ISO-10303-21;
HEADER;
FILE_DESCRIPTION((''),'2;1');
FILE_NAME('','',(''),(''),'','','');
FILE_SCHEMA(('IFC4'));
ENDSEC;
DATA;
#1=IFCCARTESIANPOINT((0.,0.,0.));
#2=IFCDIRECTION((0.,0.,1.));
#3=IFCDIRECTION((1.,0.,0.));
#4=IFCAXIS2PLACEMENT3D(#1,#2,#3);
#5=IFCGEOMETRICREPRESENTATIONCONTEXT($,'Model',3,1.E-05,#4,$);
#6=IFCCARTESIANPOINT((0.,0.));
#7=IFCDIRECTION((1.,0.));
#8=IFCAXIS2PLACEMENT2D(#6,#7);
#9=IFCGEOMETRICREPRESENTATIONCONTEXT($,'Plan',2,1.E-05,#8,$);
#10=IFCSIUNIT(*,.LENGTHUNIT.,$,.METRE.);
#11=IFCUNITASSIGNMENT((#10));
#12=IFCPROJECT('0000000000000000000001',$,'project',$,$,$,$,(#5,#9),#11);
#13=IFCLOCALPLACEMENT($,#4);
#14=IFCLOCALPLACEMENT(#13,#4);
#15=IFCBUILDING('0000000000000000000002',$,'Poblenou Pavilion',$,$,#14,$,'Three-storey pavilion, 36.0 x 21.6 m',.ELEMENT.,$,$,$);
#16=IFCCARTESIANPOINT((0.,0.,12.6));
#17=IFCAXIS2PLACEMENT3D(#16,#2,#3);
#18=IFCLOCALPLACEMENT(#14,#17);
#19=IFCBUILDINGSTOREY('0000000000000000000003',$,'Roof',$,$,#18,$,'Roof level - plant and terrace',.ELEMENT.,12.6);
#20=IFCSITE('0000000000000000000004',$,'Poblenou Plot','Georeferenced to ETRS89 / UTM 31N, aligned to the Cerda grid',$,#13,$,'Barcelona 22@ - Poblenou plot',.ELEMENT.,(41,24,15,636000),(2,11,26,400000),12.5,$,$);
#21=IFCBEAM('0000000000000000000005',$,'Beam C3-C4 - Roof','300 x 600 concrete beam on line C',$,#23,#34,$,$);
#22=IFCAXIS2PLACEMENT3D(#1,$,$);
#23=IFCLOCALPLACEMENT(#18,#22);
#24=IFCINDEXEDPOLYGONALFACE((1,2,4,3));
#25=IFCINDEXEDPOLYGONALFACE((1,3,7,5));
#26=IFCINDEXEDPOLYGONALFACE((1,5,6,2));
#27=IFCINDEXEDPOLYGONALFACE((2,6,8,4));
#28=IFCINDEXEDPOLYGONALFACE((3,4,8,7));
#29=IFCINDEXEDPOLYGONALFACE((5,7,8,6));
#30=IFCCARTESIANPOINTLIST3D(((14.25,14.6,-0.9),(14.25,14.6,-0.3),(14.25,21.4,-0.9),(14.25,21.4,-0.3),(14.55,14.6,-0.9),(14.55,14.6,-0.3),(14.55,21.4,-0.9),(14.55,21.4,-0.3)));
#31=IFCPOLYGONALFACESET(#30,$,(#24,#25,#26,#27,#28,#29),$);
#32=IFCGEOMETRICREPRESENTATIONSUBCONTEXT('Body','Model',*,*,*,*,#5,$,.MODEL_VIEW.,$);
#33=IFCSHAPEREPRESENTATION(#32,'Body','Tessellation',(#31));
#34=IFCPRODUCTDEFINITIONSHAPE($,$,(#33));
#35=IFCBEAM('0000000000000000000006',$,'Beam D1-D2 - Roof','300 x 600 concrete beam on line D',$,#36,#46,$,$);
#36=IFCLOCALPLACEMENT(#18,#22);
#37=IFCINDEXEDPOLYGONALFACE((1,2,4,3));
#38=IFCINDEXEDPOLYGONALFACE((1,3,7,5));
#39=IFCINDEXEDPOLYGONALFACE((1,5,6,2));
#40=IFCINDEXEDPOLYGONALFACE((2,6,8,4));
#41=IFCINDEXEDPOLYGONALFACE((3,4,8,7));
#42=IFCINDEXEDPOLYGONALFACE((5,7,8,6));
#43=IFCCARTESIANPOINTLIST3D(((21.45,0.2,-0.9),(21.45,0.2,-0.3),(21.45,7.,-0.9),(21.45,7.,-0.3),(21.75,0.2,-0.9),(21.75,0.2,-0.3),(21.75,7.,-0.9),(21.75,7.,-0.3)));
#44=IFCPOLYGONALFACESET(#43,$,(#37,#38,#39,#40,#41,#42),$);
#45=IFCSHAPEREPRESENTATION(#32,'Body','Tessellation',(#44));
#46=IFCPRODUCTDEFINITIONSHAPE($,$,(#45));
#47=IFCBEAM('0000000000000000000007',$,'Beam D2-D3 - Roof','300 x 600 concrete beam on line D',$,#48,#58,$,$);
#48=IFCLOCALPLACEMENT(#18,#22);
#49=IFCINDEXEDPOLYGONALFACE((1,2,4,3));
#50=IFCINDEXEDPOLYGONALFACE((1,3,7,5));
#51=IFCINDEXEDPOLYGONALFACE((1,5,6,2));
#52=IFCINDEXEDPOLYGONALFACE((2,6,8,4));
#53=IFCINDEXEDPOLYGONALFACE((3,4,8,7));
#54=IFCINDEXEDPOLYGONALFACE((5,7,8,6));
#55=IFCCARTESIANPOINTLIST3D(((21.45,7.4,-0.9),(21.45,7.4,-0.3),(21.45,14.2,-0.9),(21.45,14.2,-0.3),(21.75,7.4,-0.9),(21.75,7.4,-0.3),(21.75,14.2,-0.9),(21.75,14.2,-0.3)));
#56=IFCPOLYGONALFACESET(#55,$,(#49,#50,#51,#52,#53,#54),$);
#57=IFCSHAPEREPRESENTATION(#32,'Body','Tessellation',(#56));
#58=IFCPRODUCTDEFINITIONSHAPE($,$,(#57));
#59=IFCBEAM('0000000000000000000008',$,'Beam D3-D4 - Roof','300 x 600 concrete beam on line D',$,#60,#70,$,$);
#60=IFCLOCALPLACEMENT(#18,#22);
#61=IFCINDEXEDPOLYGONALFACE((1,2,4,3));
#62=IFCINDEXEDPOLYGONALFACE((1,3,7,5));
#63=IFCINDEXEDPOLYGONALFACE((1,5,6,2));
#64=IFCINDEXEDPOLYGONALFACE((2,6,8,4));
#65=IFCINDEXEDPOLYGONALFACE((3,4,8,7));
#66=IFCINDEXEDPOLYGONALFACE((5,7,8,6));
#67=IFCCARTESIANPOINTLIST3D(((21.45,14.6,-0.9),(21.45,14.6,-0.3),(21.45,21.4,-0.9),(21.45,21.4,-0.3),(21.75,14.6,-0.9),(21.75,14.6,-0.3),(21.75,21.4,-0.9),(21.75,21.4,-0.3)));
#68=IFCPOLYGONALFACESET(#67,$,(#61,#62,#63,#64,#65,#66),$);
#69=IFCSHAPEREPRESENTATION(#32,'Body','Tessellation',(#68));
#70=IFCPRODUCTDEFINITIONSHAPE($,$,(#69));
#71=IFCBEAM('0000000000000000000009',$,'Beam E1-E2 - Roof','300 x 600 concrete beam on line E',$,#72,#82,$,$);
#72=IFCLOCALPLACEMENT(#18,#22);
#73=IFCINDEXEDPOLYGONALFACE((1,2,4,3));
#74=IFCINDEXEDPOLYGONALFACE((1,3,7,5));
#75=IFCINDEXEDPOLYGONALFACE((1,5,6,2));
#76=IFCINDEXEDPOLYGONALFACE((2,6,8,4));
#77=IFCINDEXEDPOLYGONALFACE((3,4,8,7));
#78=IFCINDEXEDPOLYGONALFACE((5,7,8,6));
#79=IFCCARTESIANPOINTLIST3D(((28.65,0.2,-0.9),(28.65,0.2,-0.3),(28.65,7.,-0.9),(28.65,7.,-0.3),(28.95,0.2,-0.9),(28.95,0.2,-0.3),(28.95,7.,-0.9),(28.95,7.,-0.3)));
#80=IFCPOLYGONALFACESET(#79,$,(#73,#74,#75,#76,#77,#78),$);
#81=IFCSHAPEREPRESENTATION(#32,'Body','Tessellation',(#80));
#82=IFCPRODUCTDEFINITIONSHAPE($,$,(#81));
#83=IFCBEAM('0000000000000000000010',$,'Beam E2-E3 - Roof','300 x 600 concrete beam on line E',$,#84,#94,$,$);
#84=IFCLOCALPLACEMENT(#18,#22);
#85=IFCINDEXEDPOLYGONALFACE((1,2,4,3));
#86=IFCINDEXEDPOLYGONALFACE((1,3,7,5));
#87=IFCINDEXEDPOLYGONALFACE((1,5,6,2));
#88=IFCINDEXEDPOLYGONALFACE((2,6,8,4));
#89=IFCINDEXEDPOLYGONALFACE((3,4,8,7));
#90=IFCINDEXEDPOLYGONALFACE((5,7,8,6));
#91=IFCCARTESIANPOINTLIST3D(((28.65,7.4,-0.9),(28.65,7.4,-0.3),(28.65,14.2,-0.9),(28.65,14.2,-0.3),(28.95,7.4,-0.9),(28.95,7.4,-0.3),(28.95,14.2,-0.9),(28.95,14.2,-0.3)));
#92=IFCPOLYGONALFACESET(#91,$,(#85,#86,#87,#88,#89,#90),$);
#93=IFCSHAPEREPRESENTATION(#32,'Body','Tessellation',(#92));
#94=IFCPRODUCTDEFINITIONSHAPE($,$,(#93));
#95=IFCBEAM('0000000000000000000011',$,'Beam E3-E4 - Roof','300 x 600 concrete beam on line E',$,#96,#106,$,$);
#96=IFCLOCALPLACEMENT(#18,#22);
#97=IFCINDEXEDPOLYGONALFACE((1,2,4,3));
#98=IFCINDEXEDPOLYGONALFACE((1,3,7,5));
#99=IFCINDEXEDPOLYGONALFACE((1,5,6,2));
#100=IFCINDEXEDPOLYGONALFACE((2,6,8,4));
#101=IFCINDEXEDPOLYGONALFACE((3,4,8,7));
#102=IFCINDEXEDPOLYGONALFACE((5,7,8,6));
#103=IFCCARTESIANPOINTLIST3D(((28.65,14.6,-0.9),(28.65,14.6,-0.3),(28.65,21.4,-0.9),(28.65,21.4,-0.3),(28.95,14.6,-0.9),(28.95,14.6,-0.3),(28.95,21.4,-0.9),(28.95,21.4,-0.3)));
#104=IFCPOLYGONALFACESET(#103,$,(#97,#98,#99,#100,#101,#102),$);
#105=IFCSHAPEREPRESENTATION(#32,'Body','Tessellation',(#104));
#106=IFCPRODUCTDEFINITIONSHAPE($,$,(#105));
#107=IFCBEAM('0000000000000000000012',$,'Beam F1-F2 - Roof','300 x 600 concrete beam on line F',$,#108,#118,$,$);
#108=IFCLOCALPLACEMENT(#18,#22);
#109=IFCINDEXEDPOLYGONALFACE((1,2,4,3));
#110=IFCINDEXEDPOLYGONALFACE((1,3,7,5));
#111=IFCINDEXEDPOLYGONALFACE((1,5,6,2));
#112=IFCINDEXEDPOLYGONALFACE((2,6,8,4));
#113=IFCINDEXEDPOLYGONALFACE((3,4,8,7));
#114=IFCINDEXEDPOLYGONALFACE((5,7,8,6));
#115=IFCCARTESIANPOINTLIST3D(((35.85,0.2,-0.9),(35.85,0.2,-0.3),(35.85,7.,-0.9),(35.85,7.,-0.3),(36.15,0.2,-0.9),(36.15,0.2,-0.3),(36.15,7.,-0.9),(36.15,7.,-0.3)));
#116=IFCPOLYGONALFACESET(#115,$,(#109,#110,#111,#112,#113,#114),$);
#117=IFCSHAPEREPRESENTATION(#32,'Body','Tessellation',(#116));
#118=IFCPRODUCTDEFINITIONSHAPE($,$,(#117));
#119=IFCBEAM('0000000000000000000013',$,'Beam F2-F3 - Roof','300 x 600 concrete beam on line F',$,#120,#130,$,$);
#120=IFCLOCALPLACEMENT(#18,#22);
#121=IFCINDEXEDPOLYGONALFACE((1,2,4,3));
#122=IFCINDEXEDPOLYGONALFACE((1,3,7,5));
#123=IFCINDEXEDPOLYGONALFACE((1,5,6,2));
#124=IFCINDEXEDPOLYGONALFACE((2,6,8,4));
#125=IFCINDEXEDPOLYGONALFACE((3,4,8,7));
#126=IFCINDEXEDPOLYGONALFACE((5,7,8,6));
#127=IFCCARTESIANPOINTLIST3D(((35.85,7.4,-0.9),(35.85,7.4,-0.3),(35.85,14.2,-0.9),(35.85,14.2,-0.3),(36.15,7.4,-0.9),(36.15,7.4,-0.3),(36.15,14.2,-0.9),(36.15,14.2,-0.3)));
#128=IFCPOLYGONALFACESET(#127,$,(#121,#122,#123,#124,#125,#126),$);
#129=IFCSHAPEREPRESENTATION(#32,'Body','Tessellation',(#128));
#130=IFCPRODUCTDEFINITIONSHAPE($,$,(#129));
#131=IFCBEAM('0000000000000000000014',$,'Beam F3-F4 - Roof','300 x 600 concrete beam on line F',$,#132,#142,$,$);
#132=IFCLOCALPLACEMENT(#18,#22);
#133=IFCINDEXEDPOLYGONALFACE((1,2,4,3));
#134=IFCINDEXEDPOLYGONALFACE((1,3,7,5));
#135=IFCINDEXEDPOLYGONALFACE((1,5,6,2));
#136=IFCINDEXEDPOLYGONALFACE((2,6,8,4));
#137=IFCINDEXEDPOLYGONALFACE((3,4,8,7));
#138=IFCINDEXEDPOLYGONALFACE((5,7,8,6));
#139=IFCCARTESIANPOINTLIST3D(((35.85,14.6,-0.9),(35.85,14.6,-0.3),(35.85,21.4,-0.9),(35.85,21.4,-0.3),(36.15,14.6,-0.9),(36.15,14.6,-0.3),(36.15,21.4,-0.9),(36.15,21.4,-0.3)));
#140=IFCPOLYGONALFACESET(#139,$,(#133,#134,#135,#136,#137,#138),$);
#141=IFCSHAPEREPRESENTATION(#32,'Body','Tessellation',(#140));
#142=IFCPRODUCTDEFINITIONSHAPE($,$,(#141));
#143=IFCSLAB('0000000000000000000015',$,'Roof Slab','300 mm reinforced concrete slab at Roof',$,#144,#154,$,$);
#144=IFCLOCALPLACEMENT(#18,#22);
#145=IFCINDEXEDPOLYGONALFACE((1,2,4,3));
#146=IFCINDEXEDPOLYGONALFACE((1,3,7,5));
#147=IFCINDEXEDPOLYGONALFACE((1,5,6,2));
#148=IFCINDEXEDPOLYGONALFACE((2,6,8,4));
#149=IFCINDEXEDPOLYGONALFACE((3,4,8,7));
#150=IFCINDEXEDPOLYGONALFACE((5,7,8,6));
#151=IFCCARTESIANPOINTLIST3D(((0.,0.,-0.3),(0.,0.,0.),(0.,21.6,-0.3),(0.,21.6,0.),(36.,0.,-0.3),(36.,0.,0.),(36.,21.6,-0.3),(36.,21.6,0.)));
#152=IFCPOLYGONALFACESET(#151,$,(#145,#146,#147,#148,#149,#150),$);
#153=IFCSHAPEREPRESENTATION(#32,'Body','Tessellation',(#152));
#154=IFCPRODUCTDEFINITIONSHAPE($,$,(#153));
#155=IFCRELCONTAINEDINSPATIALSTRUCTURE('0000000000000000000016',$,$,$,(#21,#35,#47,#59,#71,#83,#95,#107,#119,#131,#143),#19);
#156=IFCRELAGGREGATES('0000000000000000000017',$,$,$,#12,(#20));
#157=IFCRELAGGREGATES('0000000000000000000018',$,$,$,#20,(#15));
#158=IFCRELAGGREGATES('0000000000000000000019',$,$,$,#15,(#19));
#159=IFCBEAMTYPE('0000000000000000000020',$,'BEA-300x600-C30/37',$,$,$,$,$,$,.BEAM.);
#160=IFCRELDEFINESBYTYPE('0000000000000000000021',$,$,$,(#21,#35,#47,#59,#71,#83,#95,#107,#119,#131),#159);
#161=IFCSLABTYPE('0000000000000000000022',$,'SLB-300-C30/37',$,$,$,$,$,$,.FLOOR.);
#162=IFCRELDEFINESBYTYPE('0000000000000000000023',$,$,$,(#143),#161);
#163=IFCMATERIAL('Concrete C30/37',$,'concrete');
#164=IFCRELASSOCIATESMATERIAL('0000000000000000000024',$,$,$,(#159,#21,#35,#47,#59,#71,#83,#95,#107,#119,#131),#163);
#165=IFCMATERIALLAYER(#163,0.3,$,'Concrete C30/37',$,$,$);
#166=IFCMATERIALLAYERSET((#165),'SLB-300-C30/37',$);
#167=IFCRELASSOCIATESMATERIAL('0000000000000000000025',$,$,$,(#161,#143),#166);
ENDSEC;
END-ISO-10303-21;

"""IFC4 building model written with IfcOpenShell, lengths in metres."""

from ifc_helpers import new_model, si_unit, frame, origin_with_axes, origin_2d_with_axis, place, context, subcontext, project, spatial, line, indexed_curve, rectangle, outline, extrude, material, layer, layer_set, layer_usage, material_profile, profile_set, profile_usage, type_object, element, save


model = new_model("IFC4")

# Units and contexts
model_context = context("Model", 3, precision=1e-05, world=origin_with_axes())
plan_context = context("Plan", 2, precision=1e-05, world=origin_2d_with_axis())
body_context = subcontext(model_context, "Body", "Model", "MODEL_VIEW")
ifc_project = project(units=[si_unit("LENGTHUNIT", "METRE")], contexts=[model_context, plan_context])

# Site, building, storey
site_placement = place(None, origin_with_axes())
site = spatial("IfcSite", under=ifc_project, at=site_placement, Name="Poblenou Plot", Description="Georeferenced to ETRS89 / UTM 31N, aligned to the Cerda grid", LongName="Barcelona 22@ - Poblenou plot", CompositionType="ELEMENT", RefLatitude=(41, 24, 15, 636000), RefLongitude=(2, 11, 26, 400000), RefElevation=12.5)
building_placement = place(site_placement, origin_with_axes())
building = spatial("IfcBuilding", under=site, at=building_placement, Name="Poblenou Pavilion", LongName="Three-storey pavilion, 36.0 x 21.6 m", CompositionType="ELEMENT")
storey_placement = place(building_placement, frame((0.0, 0.0, 12.6), z_axis=(0.0, 0.0, 1.0), x_axis=(1.0, 0.0, 0.0)))
storey = spatial("IfcBuildingStorey", under=building, at=storey_placement, Name="Roof", LongName="Roof level - plant and terrace", CompositionType="ELEMENT", Elevation=12.6)

# Beams
ifc_material = material(Name="Concrete C30/37", Category="concrete")
ifc_material_profile = material_profile(ifc_material, rectangle(XDim=0.3, YDim=0.6))
ifc_profile_set = profile_set([ifc_material_profile], Name="BEA-300x600-C30/37")
beam_type = type_object("IfcBeamType", Name="BEA-300x600-C30/37", PredefinedType="BEAM", material=ifc_profile_set)
ifc_profile_usage_1 = profile_usage(ifc_profile_set)
beam_1_placement = place(storey_placement, frame((14.25, 14.6, -0.9), z_axis=(0.0, 1.0, 0.0), x_axis=(0.0, 0.0, 1.0)))
element("IfcBeam", 1, at=beam_1_placement, inside=storey, type_object=beam_type, material=ifc_profile_usage_1, Name="Beam C3-C4 - Roof", Description="300 x 600 concrete beam on line C", context=body_context, shape_type="SweptSolid", body=[
    extrude(outline(indexed_curve([(0.0, 0.0), (0.6, 0.0), (0.6, 0.3), (0.0, 0.3)], segments=[line(1, 2, 3, 4, 1)])), origin_with_axes(), (0.0, 0.0, 1.0), 6.8),
])
ifc_profile_usage_2 = profile_usage(ifc_profile_set)
beam_2_placement = place(storey_placement, frame((21.45, 0.2, -0.9), z_axis=(0.0, 1.0, 0.0), x_axis=(0.0, 0.0, 1.0)))
element("IfcBeam", 2, at=beam_2_placement, inside=storey, type_object=beam_type, material=ifc_profile_usage_2, Name="Beam D1-D2 - Roof", Description="300 x 600 concrete beam on line D", context=body_context, shape_type="SweptSolid", body=[
    extrude(outline(indexed_curve([(0.0, 0.0), (0.6, 0.0), (0.6, 0.3), (0.0, 0.3)], segments=[line(1, 2, 3, 4, 1)])), origin_with_axes(), (0.0, 0.0, 1.0), 6.8),
])
ifc_profile_usage_3 = profile_usage(ifc_profile_set)
beam_3_placement = place(storey_placement, frame((21.45, 7.4, -0.9), z_axis=(0.0, 1.0, 0.0), x_axis=(0.0, 0.0, 1.0)))
element("IfcBeam", 3, at=beam_3_placement, inside=storey, type_object=beam_type, material=ifc_profile_usage_3, Name="Beam D2-D3 - Roof", Description="300 x 600 concrete beam on line D", context=body_context, shape_type="SweptSolid", body=[
    extrude(outline(indexed_curve([(0.0, 0.0), (0.6, 0.0), (0.6, 0.3), (0.0, 0.3)], segments=[line(1, 2, 3, 4, 1)])), origin_with_axes(), (0.0, 0.0, 1.0), 6.8),
])
ifc_profile_usage_4 = profile_usage(ifc_profile_set)
beam_4_placement = place(storey_placement, frame((21.45, 14.6, -0.9), z_axis=(0.0, 1.0, 0.0), x_axis=(0.0, 0.0, 1.0)))
element("IfcBeam", 4, at=beam_4_placement, inside=storey, type_object=beam_type, material=ifc_profile_usage_4, Name="Beam D3-D4 - Roof", Description="300 x 600 concrete beam on line D", context=body_context, shape_type="SweptSolid", body=[
    extrude(outline(indexed_curve([(0.0, 0.0), (0.6, 0.0), (0.6, 0.3), (0.0, 0.3)], segments=[line(1, 2, 3, 4, 1)])), origin_with_axes(), (0.0, 0.0, 1.0), 6.8),
])
ifc_profile_usage_5 = profile_usage(ifc_profile_set)
beam_5_placement = place(storey_placement, frame((28.65, 0.2, -0.9), z_axis=(0.0, 1.0, 0.0), x_axis=(0.0, 0.0, 1.0)))
element("IfcBeam", 5, at=beam_5_placement, inside=storey, type_object=beam_type, material=ifc_profile_usage_5, Name="Beam E1-E2 - Roof", Description="300 x 600 concrete beam on line E", context=body_context, shape_type="SweptSolid", body=[
    extrude(outline(indexed_curve([(0.0, 0.0), (0.6, 0.0), (0.6, 0.3), (0.0, 0.3)], segments=[line(1, 2, 3, 4, 1)])), origin_with_axes(), (0.0, 0.0, 1.0), 6.8),
])
ifc_profile_usage_6 = profile_usage(ifc_profile_set)
beam_6_placement = place(storey_placement, frame((28.65, 7.4, -0.9), z_axis=(0.0, 1.0, 0.0), x_axis=(0.0, 0.0, 1.0)))
element("IfcBeam", 6, at=beam_6_placement, inside=storey, type_object=beam_type, material=ifc_profile_usage_6, Name="Beam E2-E3 - Roof", Description="300 x 600 concrete beam on line E", context=body_context, shape_type="SweptSolid", body=[
    extrude(outline(indexed_curve([(0.0, 0.0), (0.6, 0.0), (0.6, 0.3), (0.0, 0.3)], segments=[line(1, 2, 3, 4, 1)])), origin_with_axes(), (0.0, 0.0, 1.0), 6.8),
])
ifc_profile_usage_7 = profile_usage(ifc_profile_set)
beam_7_placement = place(storey_placement, frame((28.65, 14.6, -0.9), z_axis=(0.0, 1.0, 0.0), x_axis=(0.0, 0.0, 1.0)))
element("IfcBeam", 7, at=beam_7_placement, inside=storey, type_object=beam_type, material=ifc_profile_usage_7, Name="Beam E3-E4 - Roof", Description="300 x 600 concrete beam on line E", context=body_context, shape_type="SweptSolid", body=[
    extrude(outline(indexed_curve([(0.0, 0.0), (0.6, 0.0), (0.6, 0.3), (0.0, 0.3)], segments=[line(1, 2, 3, 4, 1)])), origin_with_axes(), (0.0, 0.0, 1.0), 6.8),
])
ifc_profile_usage_8 = profile_usage(ifc_profile_set)
beam_8_placement = place(storey_placement, frame((35.85, 0.2, -0.9), z_axis=(0.0, 1.0, 0.0), x_axis=(0.0, 0.0, 1.0)))
element("IfcBeam", 8, at=beam_8_placement, inside=storey, type_object=beam_type, material=ifc_profile_usage_8, Name="Beam F1-F2 - Roof", Description="300 x 600 concrete beam on line F", context=body_context, shape_type="SweptSolid", body=[
    extrude(outline(indexed_curve([(0.0, 0.0), (0.6, 0.0), (0.6, 0.3), (0.0, 0.3)], segments=[line(1, 2, 3, 4, 1)])), origin_with_axes(), (0.0, 0.0, 1.0), 6.8),
])
ifc_profile_usage_9 = profile_usage(ifc_profile_set)
beam_9_placement = place(storey_placement, frame((35.85, 7.4, -0.9), z_axis=(0.0, 1.0, 0.0), x_axis=(0.0, 0.0, 1.0)))
element("IfcBeam", 9, at=beam_9_placement, inside=storey, type_object=beam_type, material=ifc_profile_usage_9, Name="Beam F2-F3 - Roof", Description="300 x 600 concrete beam on line F", context=body_context, shape_type="SweptSolid", body=[
    extrude(outline(indexed_curve([(0.0, 0.0), (0.6, 0.0), (0.6, 0.3), (0.0, 0.3)], segments=[line(1, 2, 3, 4, 1)])), origin_with_axes(), (0.0, 0.0, 1.0), 6.8),
])
ifc_profile_usage_10 = profile_usage(ifc_profile_set)
beam_10_placement = place(storey_placement, frame((35.85, 14.6, -0.9), z_axis=(0.0, 1.0, 0.0), x_axis=(0.0, 0.0, 1.0)))
element("IfcBeam", 10, at=beam_10_placement, inside=storey, type_object=beam_type, material=ifc_profile_usage_10, Name="Beam F3-F4 - Roof", Description="300 x 600 concrete beam on line F", context=body_context, shape_type="SweptSolid", body=[
    extrude(outline(indexed_curve([(0.0, 0.0), (0.6, 0.0), (0.6, 0.3), (0.0, 0.3)], segments=[line(1, 2, 3, 4, 1)])), origin_with_axes(), (0.0, 0.0, 1.0), 6.8),
])

# Slab
ifc_layer = layer(ifc_material, 0.3, Name="Concrete C30/37")
ifc_layer_set = layer_set([ifc_layer], Name="SLB-300-C30/37")
ifc_layer_usage = layer_usage(ifc_layer_set, "AXIS3", "POSITIVE", 0.0)
slab_type = type_object("IfcSlabType", Name="SLB-300-C30/37", PredefinedType="FLOOR", material=ifc_layer_set)
slab_placement = place(storey_placement, frame((0.0, 0.0, -0.3), z_axis=(0.0, 0.0, 1.0), x_axis=(1.0, 0.0, 0.0)))
element("IfcSlab", 11, at=slab_placement, inside=storey, type_object=slab_type, material=ifc_layer_usage, Name="Roof Slab", Description="300 mm reinforced concrete slab at Roof", context=body_context, shape_type="SweptSolid", body=[
    extrude(outline(indexed_curve([(0.0, 0.0), (36.0, 0.0), (36.0, 21.6), (0.0, 21.6)], segments=[line(1, 2, 3, 4, 1)])), origin_with_axes(), (0.0, 0.0, 1.0), 0.3),
])

save(model, "model.ifc")
